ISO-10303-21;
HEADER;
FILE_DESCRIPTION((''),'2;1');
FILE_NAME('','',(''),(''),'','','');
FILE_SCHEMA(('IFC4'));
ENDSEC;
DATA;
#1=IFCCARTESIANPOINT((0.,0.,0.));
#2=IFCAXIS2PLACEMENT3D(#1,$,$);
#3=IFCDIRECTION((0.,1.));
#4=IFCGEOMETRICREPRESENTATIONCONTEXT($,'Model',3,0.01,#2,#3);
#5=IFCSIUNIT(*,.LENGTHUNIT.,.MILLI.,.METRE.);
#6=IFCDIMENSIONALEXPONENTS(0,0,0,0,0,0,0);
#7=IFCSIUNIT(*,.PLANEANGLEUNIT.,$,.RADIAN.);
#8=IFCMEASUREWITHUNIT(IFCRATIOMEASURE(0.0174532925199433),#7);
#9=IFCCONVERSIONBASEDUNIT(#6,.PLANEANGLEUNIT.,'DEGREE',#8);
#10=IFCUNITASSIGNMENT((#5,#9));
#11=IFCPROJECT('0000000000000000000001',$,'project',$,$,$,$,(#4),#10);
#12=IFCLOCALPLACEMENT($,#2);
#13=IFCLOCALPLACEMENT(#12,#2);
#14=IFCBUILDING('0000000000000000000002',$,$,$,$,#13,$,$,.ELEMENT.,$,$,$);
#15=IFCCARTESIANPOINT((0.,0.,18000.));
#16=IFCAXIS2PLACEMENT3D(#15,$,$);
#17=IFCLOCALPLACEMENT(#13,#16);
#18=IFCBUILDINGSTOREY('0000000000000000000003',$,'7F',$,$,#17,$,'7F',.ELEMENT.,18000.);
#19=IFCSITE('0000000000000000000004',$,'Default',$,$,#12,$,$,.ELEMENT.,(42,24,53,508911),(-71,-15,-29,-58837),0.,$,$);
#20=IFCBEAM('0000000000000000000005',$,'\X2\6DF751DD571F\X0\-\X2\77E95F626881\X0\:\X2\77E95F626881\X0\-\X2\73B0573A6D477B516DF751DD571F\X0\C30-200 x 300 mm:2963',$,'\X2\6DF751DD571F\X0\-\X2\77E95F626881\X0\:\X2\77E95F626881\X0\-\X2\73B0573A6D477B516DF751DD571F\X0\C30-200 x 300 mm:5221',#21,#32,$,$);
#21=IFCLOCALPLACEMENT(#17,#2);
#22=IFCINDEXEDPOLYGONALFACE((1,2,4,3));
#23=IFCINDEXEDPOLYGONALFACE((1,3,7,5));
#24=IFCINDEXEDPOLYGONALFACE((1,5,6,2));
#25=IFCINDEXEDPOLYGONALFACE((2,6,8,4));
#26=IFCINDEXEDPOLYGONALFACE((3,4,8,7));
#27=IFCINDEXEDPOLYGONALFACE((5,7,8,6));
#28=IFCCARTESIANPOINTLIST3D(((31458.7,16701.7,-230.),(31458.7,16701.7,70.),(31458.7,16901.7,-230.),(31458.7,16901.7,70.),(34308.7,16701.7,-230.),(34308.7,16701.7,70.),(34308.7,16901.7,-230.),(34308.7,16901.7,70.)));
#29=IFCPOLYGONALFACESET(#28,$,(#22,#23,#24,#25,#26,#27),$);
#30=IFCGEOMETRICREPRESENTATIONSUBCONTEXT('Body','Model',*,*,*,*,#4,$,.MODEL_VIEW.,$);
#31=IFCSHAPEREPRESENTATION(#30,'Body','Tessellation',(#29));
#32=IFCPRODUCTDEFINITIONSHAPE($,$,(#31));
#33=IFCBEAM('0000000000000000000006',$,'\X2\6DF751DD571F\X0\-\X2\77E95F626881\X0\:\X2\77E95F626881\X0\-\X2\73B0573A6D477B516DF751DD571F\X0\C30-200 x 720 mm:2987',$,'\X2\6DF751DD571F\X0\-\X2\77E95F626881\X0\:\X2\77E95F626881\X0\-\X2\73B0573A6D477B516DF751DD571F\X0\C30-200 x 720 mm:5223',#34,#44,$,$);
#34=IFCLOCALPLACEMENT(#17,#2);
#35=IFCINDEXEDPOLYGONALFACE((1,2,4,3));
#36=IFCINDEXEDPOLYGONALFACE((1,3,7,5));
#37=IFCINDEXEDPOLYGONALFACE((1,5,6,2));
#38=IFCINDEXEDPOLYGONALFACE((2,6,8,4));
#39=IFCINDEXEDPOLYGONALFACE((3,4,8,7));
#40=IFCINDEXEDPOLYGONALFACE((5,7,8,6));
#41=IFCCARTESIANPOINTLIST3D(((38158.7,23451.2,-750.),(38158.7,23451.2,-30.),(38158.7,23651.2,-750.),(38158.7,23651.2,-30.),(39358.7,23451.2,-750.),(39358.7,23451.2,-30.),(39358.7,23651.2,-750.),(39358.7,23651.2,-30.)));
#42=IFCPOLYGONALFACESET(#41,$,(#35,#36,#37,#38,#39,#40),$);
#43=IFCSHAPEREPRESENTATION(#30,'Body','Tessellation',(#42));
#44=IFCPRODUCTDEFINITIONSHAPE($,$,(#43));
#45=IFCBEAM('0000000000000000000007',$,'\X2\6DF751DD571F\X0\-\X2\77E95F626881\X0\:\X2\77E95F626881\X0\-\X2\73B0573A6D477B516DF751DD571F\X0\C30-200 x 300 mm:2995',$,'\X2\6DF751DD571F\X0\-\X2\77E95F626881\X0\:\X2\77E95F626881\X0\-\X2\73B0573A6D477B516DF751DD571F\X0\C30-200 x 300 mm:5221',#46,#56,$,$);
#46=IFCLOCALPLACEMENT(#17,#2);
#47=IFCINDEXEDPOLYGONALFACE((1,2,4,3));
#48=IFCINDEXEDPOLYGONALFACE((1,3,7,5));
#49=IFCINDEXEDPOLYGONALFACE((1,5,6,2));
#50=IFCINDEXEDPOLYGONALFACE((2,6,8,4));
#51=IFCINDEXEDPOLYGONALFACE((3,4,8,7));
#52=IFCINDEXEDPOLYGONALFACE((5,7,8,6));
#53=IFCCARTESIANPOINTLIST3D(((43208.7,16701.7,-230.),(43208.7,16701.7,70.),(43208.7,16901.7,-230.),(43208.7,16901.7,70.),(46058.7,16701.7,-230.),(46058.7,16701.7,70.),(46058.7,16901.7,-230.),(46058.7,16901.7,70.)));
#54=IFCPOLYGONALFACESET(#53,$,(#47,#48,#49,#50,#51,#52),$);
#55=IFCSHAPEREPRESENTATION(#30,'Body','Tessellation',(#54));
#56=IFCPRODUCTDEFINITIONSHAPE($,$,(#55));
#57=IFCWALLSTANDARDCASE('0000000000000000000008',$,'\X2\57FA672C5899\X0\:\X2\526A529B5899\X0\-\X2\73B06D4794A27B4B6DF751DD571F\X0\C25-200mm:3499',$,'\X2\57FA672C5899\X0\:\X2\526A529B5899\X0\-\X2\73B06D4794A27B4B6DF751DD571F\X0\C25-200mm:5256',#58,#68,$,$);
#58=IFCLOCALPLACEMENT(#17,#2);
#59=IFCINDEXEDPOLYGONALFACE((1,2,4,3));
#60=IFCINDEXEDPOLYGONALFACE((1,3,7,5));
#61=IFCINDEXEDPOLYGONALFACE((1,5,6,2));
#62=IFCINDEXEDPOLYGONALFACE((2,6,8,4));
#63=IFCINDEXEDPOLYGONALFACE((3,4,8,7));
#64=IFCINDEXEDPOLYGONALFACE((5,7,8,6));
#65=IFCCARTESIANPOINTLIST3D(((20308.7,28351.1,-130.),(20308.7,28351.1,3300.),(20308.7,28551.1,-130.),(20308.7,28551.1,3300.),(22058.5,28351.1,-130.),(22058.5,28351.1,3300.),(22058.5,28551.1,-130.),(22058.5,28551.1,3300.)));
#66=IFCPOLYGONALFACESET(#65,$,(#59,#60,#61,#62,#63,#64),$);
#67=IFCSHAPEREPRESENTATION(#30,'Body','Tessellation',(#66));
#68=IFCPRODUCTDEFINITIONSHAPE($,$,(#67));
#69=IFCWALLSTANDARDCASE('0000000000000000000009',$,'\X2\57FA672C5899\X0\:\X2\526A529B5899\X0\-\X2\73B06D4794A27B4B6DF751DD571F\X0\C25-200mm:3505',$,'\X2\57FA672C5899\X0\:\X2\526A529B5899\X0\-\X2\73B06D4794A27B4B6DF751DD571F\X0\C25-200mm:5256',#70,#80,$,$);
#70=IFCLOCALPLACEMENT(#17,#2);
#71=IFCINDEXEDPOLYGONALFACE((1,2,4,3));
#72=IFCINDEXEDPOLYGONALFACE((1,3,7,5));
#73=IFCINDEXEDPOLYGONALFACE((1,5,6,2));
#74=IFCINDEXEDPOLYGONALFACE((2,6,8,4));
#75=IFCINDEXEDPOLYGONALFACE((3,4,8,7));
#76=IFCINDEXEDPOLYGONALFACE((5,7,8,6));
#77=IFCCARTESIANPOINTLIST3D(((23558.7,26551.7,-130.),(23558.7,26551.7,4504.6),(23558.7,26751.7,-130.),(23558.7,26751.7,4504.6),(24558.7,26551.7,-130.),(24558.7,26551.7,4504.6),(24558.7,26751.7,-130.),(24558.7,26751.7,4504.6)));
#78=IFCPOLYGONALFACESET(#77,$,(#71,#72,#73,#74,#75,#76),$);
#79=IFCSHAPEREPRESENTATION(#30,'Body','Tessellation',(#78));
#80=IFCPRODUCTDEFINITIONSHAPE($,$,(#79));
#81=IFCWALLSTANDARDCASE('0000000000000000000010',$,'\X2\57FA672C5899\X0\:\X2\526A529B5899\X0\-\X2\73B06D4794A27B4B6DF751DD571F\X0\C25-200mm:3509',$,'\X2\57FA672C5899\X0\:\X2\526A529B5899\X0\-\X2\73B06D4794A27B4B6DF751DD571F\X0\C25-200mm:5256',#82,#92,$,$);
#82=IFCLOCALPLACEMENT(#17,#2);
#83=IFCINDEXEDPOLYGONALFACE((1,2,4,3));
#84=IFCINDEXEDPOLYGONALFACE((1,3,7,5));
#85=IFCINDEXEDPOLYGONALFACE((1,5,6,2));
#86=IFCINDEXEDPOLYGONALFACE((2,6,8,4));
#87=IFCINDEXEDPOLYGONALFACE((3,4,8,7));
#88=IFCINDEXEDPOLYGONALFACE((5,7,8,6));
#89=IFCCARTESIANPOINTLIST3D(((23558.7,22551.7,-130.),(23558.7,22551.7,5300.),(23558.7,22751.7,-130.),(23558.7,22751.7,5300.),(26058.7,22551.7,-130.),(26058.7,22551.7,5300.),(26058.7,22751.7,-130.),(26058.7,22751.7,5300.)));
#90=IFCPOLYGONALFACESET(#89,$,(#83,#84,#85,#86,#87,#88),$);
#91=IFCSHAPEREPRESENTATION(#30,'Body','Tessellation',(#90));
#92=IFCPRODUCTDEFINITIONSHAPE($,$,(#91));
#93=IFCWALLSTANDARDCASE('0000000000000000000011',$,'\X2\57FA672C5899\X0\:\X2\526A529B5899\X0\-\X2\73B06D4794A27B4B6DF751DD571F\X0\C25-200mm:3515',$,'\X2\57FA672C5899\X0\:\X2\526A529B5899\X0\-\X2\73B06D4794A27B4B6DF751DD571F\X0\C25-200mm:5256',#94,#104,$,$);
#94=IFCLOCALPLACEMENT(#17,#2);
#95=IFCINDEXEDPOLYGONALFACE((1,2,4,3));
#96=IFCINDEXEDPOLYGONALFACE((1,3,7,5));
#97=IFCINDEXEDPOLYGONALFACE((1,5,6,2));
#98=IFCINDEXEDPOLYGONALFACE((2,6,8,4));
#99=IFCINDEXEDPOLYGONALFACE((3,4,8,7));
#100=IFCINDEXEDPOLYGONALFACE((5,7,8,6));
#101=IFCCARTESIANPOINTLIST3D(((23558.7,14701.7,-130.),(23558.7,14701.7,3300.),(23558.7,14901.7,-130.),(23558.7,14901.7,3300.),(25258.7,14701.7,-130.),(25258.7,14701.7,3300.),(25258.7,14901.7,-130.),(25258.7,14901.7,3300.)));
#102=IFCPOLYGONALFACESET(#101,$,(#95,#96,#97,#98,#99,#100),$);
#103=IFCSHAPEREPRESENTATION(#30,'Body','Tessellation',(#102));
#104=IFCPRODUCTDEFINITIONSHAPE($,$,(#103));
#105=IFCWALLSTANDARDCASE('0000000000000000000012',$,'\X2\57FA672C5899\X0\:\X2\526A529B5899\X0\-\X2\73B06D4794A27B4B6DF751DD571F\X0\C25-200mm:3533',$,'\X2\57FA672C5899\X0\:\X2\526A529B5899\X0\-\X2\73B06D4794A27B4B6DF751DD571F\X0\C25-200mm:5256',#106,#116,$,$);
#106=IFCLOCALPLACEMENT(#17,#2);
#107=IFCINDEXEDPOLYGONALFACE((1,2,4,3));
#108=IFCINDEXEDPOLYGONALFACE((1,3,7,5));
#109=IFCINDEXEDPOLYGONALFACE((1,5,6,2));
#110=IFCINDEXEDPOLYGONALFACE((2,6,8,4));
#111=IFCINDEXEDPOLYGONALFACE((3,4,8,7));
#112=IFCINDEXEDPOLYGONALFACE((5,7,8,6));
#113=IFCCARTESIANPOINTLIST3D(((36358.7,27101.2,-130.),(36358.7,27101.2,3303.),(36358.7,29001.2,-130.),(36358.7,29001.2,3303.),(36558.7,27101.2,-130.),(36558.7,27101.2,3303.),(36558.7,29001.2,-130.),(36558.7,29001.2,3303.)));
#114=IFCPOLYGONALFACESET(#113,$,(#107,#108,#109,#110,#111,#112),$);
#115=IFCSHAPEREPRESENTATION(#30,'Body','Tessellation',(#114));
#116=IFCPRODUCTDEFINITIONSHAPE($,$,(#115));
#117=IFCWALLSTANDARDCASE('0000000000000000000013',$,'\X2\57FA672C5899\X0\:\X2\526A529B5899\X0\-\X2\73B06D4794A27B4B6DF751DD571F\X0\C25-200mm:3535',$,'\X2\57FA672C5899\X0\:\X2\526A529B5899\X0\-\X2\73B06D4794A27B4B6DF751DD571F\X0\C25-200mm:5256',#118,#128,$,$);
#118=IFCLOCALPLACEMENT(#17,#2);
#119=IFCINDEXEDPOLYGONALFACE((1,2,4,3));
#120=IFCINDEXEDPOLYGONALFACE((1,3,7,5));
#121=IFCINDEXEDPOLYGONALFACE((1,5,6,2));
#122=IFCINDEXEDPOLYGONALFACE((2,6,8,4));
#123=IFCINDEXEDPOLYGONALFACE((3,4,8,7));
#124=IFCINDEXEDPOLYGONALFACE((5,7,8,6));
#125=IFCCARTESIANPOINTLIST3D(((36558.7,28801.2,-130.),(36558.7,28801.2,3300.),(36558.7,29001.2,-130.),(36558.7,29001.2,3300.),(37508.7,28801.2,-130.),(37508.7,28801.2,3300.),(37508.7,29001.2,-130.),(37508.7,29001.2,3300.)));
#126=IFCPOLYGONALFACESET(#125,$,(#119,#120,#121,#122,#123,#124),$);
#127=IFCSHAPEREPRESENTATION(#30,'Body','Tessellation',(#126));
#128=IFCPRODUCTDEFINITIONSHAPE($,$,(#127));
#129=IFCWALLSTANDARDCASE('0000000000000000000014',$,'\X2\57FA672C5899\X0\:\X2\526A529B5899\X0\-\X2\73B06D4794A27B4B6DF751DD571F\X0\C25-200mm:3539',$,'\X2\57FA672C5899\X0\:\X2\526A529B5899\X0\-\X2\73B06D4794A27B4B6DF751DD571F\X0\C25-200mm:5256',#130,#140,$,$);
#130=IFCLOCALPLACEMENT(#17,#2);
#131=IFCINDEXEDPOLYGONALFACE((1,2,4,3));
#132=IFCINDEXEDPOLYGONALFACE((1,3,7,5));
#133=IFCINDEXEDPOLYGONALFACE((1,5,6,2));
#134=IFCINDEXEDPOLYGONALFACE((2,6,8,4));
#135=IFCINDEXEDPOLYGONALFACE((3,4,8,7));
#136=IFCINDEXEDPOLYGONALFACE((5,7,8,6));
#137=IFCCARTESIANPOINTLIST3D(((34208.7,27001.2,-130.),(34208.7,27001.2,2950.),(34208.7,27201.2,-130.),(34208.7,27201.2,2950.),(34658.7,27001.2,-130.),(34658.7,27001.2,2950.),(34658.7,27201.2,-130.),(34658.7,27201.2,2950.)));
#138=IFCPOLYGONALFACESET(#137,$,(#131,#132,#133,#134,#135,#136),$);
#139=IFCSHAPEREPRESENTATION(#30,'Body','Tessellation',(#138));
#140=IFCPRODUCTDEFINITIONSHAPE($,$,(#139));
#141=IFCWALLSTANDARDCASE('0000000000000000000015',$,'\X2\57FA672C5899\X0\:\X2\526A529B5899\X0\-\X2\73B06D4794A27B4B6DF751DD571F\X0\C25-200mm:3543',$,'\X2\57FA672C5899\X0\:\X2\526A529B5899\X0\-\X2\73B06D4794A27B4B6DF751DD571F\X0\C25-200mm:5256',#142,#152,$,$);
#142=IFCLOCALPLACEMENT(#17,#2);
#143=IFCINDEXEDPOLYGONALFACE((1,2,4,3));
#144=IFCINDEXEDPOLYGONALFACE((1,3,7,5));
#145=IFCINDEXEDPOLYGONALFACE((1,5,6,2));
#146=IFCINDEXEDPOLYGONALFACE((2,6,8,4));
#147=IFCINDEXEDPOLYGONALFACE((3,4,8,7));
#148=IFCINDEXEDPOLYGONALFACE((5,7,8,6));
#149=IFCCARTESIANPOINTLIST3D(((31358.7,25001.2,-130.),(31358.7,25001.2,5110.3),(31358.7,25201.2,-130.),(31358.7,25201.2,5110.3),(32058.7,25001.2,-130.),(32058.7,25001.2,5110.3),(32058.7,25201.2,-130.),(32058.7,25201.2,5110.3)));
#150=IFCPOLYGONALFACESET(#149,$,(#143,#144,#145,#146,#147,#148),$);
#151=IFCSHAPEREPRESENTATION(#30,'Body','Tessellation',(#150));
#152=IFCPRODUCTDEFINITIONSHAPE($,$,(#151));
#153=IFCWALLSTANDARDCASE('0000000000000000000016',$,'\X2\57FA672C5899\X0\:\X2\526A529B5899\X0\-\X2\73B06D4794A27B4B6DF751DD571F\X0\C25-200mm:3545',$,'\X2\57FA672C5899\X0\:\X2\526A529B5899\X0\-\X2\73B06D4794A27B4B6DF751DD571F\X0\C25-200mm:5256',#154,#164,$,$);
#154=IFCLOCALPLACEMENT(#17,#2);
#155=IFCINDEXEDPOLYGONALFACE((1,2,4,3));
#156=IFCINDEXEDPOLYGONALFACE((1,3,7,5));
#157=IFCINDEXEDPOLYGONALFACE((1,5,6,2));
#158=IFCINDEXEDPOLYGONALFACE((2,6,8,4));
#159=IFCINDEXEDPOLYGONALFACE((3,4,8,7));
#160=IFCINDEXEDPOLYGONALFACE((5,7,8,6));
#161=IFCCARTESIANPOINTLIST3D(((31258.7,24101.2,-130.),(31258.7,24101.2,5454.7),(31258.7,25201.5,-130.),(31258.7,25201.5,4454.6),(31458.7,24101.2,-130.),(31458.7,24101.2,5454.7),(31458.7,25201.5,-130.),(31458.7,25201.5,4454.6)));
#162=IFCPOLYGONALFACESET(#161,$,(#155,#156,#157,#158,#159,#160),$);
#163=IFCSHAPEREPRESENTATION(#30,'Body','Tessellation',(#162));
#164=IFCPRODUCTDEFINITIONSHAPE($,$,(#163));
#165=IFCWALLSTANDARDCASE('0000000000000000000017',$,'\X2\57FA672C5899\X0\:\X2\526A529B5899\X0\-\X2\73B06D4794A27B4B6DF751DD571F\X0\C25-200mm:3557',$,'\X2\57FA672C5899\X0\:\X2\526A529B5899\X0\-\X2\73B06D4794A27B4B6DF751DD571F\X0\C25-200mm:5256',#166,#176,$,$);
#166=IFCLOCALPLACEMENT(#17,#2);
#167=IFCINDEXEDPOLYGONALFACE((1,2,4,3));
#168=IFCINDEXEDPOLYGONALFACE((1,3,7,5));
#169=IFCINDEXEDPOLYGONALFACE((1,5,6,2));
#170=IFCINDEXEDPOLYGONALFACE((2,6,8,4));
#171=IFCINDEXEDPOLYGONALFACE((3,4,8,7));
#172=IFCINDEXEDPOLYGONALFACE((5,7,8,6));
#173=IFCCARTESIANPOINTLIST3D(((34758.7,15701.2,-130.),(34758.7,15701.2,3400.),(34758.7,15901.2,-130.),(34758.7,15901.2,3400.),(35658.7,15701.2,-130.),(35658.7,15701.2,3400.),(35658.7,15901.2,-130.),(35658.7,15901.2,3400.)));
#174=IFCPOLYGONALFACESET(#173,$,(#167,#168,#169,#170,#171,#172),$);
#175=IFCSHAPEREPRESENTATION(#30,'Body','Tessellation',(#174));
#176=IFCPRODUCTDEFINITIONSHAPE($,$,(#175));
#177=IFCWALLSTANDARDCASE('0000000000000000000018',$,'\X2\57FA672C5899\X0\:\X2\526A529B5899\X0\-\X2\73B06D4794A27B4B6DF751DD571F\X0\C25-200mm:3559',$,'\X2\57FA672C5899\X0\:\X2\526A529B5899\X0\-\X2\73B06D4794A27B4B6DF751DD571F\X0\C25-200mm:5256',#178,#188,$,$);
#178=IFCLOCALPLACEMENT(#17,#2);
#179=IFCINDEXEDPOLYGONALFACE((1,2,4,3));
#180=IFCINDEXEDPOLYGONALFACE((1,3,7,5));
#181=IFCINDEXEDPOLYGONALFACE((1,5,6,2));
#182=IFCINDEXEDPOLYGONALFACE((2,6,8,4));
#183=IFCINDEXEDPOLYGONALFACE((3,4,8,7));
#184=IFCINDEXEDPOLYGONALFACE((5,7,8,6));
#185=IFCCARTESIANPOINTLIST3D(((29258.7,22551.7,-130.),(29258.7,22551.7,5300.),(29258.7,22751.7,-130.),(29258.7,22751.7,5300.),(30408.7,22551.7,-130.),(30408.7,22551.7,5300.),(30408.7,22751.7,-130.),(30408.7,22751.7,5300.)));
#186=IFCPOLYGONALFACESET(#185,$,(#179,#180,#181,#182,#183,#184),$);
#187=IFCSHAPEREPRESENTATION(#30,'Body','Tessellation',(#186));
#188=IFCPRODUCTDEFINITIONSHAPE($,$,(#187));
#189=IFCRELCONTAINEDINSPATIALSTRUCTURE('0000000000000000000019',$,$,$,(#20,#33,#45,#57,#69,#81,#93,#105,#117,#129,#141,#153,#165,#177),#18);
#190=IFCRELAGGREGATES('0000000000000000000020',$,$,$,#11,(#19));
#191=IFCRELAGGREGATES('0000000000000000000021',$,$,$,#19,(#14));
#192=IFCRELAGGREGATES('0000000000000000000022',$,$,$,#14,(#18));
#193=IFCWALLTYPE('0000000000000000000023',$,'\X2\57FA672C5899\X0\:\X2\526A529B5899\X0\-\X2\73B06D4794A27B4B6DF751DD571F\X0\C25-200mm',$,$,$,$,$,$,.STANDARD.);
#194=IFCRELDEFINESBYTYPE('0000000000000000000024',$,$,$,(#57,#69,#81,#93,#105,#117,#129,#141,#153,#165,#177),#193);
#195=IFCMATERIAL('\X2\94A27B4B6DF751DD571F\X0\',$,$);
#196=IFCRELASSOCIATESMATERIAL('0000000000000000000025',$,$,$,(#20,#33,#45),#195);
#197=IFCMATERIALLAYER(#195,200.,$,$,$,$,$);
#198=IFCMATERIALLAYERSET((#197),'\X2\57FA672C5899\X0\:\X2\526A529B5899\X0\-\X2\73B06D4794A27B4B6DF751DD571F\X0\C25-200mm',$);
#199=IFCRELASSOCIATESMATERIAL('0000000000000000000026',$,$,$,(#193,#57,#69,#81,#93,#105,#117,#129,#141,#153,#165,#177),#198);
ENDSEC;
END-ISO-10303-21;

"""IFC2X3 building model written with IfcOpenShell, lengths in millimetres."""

from ifc_helpers import new_model, entity, si_unit, converted_unit, direction, frame, frame_2d, origin, place, context, subcontext, project, spatial, rectangle, extrude, clip, halfspace, material, layer, layer_set, layer_usage, type_object, element, save


model = new_model("IFC2X3")

# Units and contexts
model_context = context("Model", 3, precision=0.01, world=origin(), true_north=direction((0.0, 1.0)))
body_context = subcontext(model_context, "Body", "Model", "MODEL_VIEW")
ifc_project = project(units=[si_unit("LENGTHUNIT", "METRE", prefix="MILLI"), converted_unit("PLANEANGLEUNIT", "DEGREE", entity("IfcRatioMeasure", 0.0174532925199433), si_unit("PLANEANGLEUNIT", "RADIAN"), dimensions=[0, 0, 0, 0, 0, 0, 0])], contexts=[model_context])

# Site, building, storey
site_placement = place(None, origin())
site = spatial("IfcSite", under=ifc_project, at=site_placement, Name="Default", CompositionType="ELEMENT", RefLatitude=(42, 24, 53, 508911), RefLongitude=(-71, -15, -29, -58837), RefElevation=0.0)
building_placement = place(site_placement, origin())
building = spatial("IfcBuilding", under=site, at=building_placement, CompositionType="ELEMENT")
storey_placement = place(building_placement, frame((0.0, 0.0, 18000.0)))
storey = spatial("IfcBuildingStorey", under=building, at=storey_placement, Name="7F", LongName="7F", CompositionType="ELEMENT", Elevation=18000.0)

# Beams
ifc_material = material(Name="钢筋混凝土")
beam_1_placement = place(storey_placement, frame((31358.7, 16801.7, 70.0)))
element("IfcBeam", 1, at=beam_1_placement, inside=storey, material=ifc_material, Name="混凝土-矩形梁:矩形梁-现场浇筑混凝土C30-200 x 300 mm:2963", ObjectType="混凝土-矩形梁:矩形梁-现场浇筑混凝土C30-200 x 300 mm:5221", context=body_context, shape_type="SweptSolid", body=[
    extrude(rectangle(XDim=300.0, YDim=200.0, at=frame_2d((0.0, 0.0), x_axis=(1.0, 0.0))), frame((100.0, 0.0, -150.0), z_axis=(1.0, 0.0, 0.0), x_axis=(0.0, 0.0, -1.0)), (0.0, 0.0, 1.0), 2850.0),
])
beam_2_placement = place(storey_placement, frame((37408.7, 23551.2, -30.0)))
element("IfcBeam", 2, at=beam_2_placement, inside=storey, material=ifc_material, Name="混凝土-矩形梁:矩形梁-现场浇筑混凝土C30-200 x 720 mm:2987", ObjectType="混凝土-矩形梁:矩形梁-现场浇筑混凝土C30-200 x 720 mm:5223", context=body_context, shape_type="SweptSolid", body=[
    extrude(rectangle(XDim=720.0, YDim=200.0, at=frame_2d((0.0, 0.0), x_axis=(1.0, 0.0))), frame((750.0, 0.0, -360.0), z_axis=(1.0, 0.0, 0.0), x_axis=(0.0, 0.0, -1.0)), (0.0, 0.0, 1.0), 1200.1),
])
beam_3_placement = place(storey_placement, frame((46158.7, 16801.7, 70.0), z_axis=(0.0, 0.0, 1.0), x_axis=(-1.0, 0.0, 0.0)))
element("IfcBeam", 3, at=beam_3_placement, inside=storey, material=ifc_material, Name="混凝土-矩形梁:矩形梁-现场浇筑混凝土C30-200 x 300 mm:2995", ObjectType="混凝土-矩形梁:矩形梁-现场浇筑混凝土C30-200 x 300 mm:5221", context=body_context, shape_type="SweptSolid", body=[
    extrude(rectangle(XDim=300.0, YDim=200.0, at=frame_2d((0.0, 0.0), x_axis=(1.0, 0.0))), frame((100.0, 0.0, -150.0), z_axis=(1.0, 0.0, 0.0), x_axis=(0.0, 0.0, -1.0)), (0.0, 0.0, 1.0), 2850.0),
])

# Wall
ifc_layer = layer(ifc_material, 200.0)
ifc_layer_set = layer_set([ifc_layer], Name="基本墙:剪力墙-现浇钢筋混凝土C25-200mm")
ifc_layer_usage_1 = layer_usage(ifc_layer_set, "AXIS2", "POSITIVE", -100.0)
wall_type = type_object("IfcWallType", Name="基本墙:剪力墙-现浇钢筋混凝土C25-200mm", PredefinedType="STANDARD", material=ifc_layer_set)
wall_1_placement = place(storey_placement, frame((22058.5, 28451.1, -130.0), z_axis=(0.0, 0.0, 1.0), x_axis=(-1.0, 0.0, 0.0)))
element("IfcWallStandardCase", 4, at=wall_1_placement, inside=storey, type_object=wall_type, material=ifc_layer_usage_1, Name="基本墙:剪力墙-现浇钢筋混凝土C25-200mm:3499", ObjectType="基本墙:剪力墙-现浇钢筋混凝土C25-200mm:5256", context=body_context, shape_type="SweptSolid", body=[
    extrude(rectangle(XDim=1749.9, YDim=200.0, at=frame_2d((874.9, 0.0), x_axis=(-1.0, 0.0))), origin(), (0.0, 0.0, 1.0), 3430.0),
])

# Walls
ifc_layer_usage_2 = layer_usage(ifc_layer_set, "AXIS2", "POSITIVE", -100.0)
wall_2_placement = place(storey_placement, frame((24558.7, 26651.7, -130.0), z_axis=(0.0, 0.0, 1.0), x_axis=(-1.0, 0.0, 0.0)))
element("IfcWallStandardCase", 5, at=wall_2_placement, inside=storey, type_object=wall_type, material=ifc_layer_usage_2, Name="基本墙:剪力墙-现浇钢筋混凝土C25-200mm:3505", ObjectType="基本墙:剪力墙-现浇钢筋混凝土C25-200mm:5256", context=body_context, shape_type="SweptSolid", body=[
    extrude(rectangle(XDim=1000.0, YDim=200.0, at=frame_2d((500.0, 0.0), x_axis=(-1.0, 0.0))), origin(), (0.0, 0.0, 1.0), 4634.6),
])
ifc_layer_usage_3 = layer_usage(ifc_layer_set, "AXIS2", "POSITIVE", -100.0)
wall_3_placement = place(storey_placement, frame((26058.7, 22651.7, -130.0), z_axis=(0.0, 0.0, 1.0), x_axis=(-1.0, 0.0, 0.0)))
element("IfcWallStandardCase", 6, at=wall_3_placement, inside=storey, type_object=wall_type, material=ifc_layer_usage_3, Name="基本墙:剪力墙-现浇钢筋混凝土C25-200mm:3509", ObjectType="基本墙:剪力墙-现浇钢筋混凝土C25-200mm:5256", context=body_context, shape_type="SweptSolid", body=[
    extrude(rectangle(XDim=2500.1, YDim=200.0, at=frame_2d((1250.0, 0.0), x_axis=(-1.0, 0.0))), origin(), (0.0, 0.0, 1.0), 5430.0),
])
ifc_layer_usage_4 = layer_usage(ifc_layer_set, "AXIS2", "POSITIVE", -100.0)
wall_4_placement = place(storey_placement, frame((25258.7, 14801.7, -130.0), z_axis=(0.0, 0.0, 1.0), x_axis=(-1.0, 0.0, 0.0)))
element("IfcWallStandardCase", 7, at=wall_4_placement, inside=storey, type_object=wall_type, material=ifc_layer_usage_4, Name="基本墙:剪力墙-现浇钢筋混凝土C25-200mm:3515", ObjectType="基本墙:剪力墙-现浇钢筋混凝土C25-200mm:5256", context=body_context, shape_type="SweptSolid", body=[
    extrude(rectangle(XDim=1700.0, YDim=200.0, at=frame_2d((850.0, 0.0), x_axis=(-1.0, 0.0))), origin(), (0.0, 0.0, 1.0), 3430.0),
])
ifc_layer_usage_5 = layer_usage(ifc_layer_set, "AXIS2", "NEGATIVE", 100.0)
wall_5_placement = place(storey_placement, frame((36458.7, 27101.2, -130.0), z_axis=(0.0, 0.0, 1.0), x_axis=(0.0, 1.0, 0.0)))
element("IfcWallStandardCase", 8, at=wall_5_placement, inside=storey, type_object=wall_type, material=ifc_layer_usage_5, Name="基本墙:剪力墙-现浇钢筋混凝土C25-200mm:3533", ObjectType="基本墙:剪力墙-现浇钢筋混凝土C25-200mm:5256", context=body_context, shape_type="Clipping", body=[
    clip(extrude(rectangle(XDim=1900.0, YDim=200.0, at=frame_2d((950.0, 0.0), x_axis=(-1.0, 0.0))), origin(), (0.0, 0.0, 1.0), 3433.0), halfspace(frame((0.0, -100.0, 3433.0), z_axis=(0.0, 0.0, 1.0), x_axis=(0.0, 1.0, 0.0)), False)),
])
ifc_layer_usage_6 = layer_usage(ifc_layer_set, "AXIS2", "NEGATIVE", 100.0)
wall_6_placement = place(storey_placement, frame((36558.7, 28901.2, -130.0)))
element("IfcWallStandardCase", 9, at=wall_6_placement, inside=storey, type_object=wall_type, material=ifc_layer_usage_6, Name="基本墙:剪力墙-现浇钢筋混凝土C25-200mm:3535", ObjectType="基本墙:剪力墙-现浇钢筋混凝土C25-200mm:5256", context=body_context, shape_type="SweptSolid", body=[
    extrude(rectangle(XDim=950.0, YDim=200.0, at=frame_2d((475.0, 0.0), x_axis=(-1.0, 0.0))), origin(), (0.0, 0.0, 1.0), 3430.0),
])
ifc_layer_usage_7 = layer_usage(ifc_layer_set, "AXIS2", "NEGATIVE", 100.0)
wall_7_placement = place(storey_placement, frame((34658.7, 27101.2, -130.0), z_axis=(0.0, 0.0, 1.0), x_axis=(-1.0, 0.0, 0.0)))
element("IfcWallStandardCase", 10, at=wall_7_placement, inside=storey, type_object=wall_type, material=ifc_layer_usage_7, Name="基本墙:剪力墙-现浇钢筋混凝土C25-200mm:3539", ObjectType="基本墙:剪力墙-现浇钢筋混凝土C25-200mm:5256", context=body_context, shape_type="SweptSolid", body=[
    extrude(rectangle(XDim=450.0, YDim=200.0, at=frame_2d((225.0, 0.0), x_axis=(-1.0, 0.0))), origin(), (0.0, 0.0, 1.0), 3080.0),
])
ifc_layer_usage_8 = layer_usage(ifc_layer_set, "AXIS2", "NEGATIVE", 100.0)
wall_8_placement = place(storey_placement, frame((32058.7, 25101.2, -130.0), z_axis=(0.0, 0.0, 1.0), x_axis=(-1.0, 0.0, 0.0)))
element("IfcWallStandardCase", 11, at=wall_8_placement, inside=storey, type_object=wall_type, material=ifc_layer_usage_8, Name="基本墙:剪力墙-现浇钢筋混凝土C25-200mm:3543", ObjectType="基本墙:剪力墙-现浇钢筋混凝土C25-200mm:5256", context=body_context, shape_type="SweptSolid", body=[
    extrude(rectangle(XDim=700.0, YDim=200.0, at=frame_2d((350.0, 0.0), x_axis=(-1.0, 0.0))), origin(), (0.0, 0.0, 1.0), 5240.3),
])
ifc_layer_usage_9 = layer_usage(ifc_layer_set, "AXIS2", "NEGATIVE", 100.0)
wall_9_placement = place(storey_placement, frame((31358.7, 25201.5, -130.0), z_axis=(0.0, 0.0, 1.0), x_axis=(0.0, -1.0, 0.0)))
element("IfcWallStandardCase", 12, at=wall_9_placement, inside=storey, type_object=wall_type, material=ifc_layer_usage_9, Name="基本墙:剪力墙-现浇钢筋混凝土C25-200mm:3545", ObjectType="基本墙:剪力墙-现浇钢筋混凝土C25-200mm:5256", context=body_context, shape_type="Clipping", body=[
    clip(extrude(rectangle(XDim=1100.2, YDim=200.0, at=frame_2d((550.1, 0.0), x_axis=(-1.0, 0.0))), origin(), (0.0, 0.0, 1.0), 5584.7), halfspace(frame((0.0, -100.0, 4584.6), z_axis=(-0.672601, 0.0, 0.740005), x_axis=(0.0, 1.0, 0.0)), False)),
])
ifc_layer_usage_10 = layer_usage(ifc_layer_set, "AXIS2", "NEGATIVE", 100.0)
wall_10_placement = place(storey_placement, frame((34758.7, 15801.2, -130.0)))
element("IfcWallStandardCase", 13, at=wall_10_placement, inside=storey, type_object=wall_type, material=ifc_layer_usage_10, Name="基本墙:剪力墙-现浇钢筋混凝土C25-200mm:3557", ObjectType="基本墙:剪力墙-现浇钢筋混凝土C25-200mm:5256", context=body_context, shape_type="SweptSolid", body=[
    extrude(rectangle(XDim=900.0, YDim=200.0, at=frame_2d((450.0, 0.0), x_axis=(-1.0, 0.0))), origin(), (0.0, 0.0, 1.0), 3530.0),
])
ifc_layer_usage_11 = layer_usage(ifc_layer_set, "AXIS2", "NEGATIVE", 100.0)
wall_11_placement = place(storey_placement, frame((29258.7, 22651.7, -130.0)))
element("IfcWallStandardCase", 14, at=wall_11_placement, inside=storey, type_object=wall_type, material=ifc_layer_usage_11, Name="基本墙:剪力墙-现浇钢筋混凝土C25-200mm:3559", ObjectType="基本墙:剪力墙-现浇钢筋混凝土C25-200mm:5256", context=body_context, shape_type="SweptSolid", body=[
    extrude(rectangle(XDim=1150.0, YDim=200.0, at=frame_2d((575.0, 0.0), x_axis=(-1.0, 0.0))), origin(), (0.0, 0.0, 1.0), 5430.0),
])

save(model, "model.ifc")
